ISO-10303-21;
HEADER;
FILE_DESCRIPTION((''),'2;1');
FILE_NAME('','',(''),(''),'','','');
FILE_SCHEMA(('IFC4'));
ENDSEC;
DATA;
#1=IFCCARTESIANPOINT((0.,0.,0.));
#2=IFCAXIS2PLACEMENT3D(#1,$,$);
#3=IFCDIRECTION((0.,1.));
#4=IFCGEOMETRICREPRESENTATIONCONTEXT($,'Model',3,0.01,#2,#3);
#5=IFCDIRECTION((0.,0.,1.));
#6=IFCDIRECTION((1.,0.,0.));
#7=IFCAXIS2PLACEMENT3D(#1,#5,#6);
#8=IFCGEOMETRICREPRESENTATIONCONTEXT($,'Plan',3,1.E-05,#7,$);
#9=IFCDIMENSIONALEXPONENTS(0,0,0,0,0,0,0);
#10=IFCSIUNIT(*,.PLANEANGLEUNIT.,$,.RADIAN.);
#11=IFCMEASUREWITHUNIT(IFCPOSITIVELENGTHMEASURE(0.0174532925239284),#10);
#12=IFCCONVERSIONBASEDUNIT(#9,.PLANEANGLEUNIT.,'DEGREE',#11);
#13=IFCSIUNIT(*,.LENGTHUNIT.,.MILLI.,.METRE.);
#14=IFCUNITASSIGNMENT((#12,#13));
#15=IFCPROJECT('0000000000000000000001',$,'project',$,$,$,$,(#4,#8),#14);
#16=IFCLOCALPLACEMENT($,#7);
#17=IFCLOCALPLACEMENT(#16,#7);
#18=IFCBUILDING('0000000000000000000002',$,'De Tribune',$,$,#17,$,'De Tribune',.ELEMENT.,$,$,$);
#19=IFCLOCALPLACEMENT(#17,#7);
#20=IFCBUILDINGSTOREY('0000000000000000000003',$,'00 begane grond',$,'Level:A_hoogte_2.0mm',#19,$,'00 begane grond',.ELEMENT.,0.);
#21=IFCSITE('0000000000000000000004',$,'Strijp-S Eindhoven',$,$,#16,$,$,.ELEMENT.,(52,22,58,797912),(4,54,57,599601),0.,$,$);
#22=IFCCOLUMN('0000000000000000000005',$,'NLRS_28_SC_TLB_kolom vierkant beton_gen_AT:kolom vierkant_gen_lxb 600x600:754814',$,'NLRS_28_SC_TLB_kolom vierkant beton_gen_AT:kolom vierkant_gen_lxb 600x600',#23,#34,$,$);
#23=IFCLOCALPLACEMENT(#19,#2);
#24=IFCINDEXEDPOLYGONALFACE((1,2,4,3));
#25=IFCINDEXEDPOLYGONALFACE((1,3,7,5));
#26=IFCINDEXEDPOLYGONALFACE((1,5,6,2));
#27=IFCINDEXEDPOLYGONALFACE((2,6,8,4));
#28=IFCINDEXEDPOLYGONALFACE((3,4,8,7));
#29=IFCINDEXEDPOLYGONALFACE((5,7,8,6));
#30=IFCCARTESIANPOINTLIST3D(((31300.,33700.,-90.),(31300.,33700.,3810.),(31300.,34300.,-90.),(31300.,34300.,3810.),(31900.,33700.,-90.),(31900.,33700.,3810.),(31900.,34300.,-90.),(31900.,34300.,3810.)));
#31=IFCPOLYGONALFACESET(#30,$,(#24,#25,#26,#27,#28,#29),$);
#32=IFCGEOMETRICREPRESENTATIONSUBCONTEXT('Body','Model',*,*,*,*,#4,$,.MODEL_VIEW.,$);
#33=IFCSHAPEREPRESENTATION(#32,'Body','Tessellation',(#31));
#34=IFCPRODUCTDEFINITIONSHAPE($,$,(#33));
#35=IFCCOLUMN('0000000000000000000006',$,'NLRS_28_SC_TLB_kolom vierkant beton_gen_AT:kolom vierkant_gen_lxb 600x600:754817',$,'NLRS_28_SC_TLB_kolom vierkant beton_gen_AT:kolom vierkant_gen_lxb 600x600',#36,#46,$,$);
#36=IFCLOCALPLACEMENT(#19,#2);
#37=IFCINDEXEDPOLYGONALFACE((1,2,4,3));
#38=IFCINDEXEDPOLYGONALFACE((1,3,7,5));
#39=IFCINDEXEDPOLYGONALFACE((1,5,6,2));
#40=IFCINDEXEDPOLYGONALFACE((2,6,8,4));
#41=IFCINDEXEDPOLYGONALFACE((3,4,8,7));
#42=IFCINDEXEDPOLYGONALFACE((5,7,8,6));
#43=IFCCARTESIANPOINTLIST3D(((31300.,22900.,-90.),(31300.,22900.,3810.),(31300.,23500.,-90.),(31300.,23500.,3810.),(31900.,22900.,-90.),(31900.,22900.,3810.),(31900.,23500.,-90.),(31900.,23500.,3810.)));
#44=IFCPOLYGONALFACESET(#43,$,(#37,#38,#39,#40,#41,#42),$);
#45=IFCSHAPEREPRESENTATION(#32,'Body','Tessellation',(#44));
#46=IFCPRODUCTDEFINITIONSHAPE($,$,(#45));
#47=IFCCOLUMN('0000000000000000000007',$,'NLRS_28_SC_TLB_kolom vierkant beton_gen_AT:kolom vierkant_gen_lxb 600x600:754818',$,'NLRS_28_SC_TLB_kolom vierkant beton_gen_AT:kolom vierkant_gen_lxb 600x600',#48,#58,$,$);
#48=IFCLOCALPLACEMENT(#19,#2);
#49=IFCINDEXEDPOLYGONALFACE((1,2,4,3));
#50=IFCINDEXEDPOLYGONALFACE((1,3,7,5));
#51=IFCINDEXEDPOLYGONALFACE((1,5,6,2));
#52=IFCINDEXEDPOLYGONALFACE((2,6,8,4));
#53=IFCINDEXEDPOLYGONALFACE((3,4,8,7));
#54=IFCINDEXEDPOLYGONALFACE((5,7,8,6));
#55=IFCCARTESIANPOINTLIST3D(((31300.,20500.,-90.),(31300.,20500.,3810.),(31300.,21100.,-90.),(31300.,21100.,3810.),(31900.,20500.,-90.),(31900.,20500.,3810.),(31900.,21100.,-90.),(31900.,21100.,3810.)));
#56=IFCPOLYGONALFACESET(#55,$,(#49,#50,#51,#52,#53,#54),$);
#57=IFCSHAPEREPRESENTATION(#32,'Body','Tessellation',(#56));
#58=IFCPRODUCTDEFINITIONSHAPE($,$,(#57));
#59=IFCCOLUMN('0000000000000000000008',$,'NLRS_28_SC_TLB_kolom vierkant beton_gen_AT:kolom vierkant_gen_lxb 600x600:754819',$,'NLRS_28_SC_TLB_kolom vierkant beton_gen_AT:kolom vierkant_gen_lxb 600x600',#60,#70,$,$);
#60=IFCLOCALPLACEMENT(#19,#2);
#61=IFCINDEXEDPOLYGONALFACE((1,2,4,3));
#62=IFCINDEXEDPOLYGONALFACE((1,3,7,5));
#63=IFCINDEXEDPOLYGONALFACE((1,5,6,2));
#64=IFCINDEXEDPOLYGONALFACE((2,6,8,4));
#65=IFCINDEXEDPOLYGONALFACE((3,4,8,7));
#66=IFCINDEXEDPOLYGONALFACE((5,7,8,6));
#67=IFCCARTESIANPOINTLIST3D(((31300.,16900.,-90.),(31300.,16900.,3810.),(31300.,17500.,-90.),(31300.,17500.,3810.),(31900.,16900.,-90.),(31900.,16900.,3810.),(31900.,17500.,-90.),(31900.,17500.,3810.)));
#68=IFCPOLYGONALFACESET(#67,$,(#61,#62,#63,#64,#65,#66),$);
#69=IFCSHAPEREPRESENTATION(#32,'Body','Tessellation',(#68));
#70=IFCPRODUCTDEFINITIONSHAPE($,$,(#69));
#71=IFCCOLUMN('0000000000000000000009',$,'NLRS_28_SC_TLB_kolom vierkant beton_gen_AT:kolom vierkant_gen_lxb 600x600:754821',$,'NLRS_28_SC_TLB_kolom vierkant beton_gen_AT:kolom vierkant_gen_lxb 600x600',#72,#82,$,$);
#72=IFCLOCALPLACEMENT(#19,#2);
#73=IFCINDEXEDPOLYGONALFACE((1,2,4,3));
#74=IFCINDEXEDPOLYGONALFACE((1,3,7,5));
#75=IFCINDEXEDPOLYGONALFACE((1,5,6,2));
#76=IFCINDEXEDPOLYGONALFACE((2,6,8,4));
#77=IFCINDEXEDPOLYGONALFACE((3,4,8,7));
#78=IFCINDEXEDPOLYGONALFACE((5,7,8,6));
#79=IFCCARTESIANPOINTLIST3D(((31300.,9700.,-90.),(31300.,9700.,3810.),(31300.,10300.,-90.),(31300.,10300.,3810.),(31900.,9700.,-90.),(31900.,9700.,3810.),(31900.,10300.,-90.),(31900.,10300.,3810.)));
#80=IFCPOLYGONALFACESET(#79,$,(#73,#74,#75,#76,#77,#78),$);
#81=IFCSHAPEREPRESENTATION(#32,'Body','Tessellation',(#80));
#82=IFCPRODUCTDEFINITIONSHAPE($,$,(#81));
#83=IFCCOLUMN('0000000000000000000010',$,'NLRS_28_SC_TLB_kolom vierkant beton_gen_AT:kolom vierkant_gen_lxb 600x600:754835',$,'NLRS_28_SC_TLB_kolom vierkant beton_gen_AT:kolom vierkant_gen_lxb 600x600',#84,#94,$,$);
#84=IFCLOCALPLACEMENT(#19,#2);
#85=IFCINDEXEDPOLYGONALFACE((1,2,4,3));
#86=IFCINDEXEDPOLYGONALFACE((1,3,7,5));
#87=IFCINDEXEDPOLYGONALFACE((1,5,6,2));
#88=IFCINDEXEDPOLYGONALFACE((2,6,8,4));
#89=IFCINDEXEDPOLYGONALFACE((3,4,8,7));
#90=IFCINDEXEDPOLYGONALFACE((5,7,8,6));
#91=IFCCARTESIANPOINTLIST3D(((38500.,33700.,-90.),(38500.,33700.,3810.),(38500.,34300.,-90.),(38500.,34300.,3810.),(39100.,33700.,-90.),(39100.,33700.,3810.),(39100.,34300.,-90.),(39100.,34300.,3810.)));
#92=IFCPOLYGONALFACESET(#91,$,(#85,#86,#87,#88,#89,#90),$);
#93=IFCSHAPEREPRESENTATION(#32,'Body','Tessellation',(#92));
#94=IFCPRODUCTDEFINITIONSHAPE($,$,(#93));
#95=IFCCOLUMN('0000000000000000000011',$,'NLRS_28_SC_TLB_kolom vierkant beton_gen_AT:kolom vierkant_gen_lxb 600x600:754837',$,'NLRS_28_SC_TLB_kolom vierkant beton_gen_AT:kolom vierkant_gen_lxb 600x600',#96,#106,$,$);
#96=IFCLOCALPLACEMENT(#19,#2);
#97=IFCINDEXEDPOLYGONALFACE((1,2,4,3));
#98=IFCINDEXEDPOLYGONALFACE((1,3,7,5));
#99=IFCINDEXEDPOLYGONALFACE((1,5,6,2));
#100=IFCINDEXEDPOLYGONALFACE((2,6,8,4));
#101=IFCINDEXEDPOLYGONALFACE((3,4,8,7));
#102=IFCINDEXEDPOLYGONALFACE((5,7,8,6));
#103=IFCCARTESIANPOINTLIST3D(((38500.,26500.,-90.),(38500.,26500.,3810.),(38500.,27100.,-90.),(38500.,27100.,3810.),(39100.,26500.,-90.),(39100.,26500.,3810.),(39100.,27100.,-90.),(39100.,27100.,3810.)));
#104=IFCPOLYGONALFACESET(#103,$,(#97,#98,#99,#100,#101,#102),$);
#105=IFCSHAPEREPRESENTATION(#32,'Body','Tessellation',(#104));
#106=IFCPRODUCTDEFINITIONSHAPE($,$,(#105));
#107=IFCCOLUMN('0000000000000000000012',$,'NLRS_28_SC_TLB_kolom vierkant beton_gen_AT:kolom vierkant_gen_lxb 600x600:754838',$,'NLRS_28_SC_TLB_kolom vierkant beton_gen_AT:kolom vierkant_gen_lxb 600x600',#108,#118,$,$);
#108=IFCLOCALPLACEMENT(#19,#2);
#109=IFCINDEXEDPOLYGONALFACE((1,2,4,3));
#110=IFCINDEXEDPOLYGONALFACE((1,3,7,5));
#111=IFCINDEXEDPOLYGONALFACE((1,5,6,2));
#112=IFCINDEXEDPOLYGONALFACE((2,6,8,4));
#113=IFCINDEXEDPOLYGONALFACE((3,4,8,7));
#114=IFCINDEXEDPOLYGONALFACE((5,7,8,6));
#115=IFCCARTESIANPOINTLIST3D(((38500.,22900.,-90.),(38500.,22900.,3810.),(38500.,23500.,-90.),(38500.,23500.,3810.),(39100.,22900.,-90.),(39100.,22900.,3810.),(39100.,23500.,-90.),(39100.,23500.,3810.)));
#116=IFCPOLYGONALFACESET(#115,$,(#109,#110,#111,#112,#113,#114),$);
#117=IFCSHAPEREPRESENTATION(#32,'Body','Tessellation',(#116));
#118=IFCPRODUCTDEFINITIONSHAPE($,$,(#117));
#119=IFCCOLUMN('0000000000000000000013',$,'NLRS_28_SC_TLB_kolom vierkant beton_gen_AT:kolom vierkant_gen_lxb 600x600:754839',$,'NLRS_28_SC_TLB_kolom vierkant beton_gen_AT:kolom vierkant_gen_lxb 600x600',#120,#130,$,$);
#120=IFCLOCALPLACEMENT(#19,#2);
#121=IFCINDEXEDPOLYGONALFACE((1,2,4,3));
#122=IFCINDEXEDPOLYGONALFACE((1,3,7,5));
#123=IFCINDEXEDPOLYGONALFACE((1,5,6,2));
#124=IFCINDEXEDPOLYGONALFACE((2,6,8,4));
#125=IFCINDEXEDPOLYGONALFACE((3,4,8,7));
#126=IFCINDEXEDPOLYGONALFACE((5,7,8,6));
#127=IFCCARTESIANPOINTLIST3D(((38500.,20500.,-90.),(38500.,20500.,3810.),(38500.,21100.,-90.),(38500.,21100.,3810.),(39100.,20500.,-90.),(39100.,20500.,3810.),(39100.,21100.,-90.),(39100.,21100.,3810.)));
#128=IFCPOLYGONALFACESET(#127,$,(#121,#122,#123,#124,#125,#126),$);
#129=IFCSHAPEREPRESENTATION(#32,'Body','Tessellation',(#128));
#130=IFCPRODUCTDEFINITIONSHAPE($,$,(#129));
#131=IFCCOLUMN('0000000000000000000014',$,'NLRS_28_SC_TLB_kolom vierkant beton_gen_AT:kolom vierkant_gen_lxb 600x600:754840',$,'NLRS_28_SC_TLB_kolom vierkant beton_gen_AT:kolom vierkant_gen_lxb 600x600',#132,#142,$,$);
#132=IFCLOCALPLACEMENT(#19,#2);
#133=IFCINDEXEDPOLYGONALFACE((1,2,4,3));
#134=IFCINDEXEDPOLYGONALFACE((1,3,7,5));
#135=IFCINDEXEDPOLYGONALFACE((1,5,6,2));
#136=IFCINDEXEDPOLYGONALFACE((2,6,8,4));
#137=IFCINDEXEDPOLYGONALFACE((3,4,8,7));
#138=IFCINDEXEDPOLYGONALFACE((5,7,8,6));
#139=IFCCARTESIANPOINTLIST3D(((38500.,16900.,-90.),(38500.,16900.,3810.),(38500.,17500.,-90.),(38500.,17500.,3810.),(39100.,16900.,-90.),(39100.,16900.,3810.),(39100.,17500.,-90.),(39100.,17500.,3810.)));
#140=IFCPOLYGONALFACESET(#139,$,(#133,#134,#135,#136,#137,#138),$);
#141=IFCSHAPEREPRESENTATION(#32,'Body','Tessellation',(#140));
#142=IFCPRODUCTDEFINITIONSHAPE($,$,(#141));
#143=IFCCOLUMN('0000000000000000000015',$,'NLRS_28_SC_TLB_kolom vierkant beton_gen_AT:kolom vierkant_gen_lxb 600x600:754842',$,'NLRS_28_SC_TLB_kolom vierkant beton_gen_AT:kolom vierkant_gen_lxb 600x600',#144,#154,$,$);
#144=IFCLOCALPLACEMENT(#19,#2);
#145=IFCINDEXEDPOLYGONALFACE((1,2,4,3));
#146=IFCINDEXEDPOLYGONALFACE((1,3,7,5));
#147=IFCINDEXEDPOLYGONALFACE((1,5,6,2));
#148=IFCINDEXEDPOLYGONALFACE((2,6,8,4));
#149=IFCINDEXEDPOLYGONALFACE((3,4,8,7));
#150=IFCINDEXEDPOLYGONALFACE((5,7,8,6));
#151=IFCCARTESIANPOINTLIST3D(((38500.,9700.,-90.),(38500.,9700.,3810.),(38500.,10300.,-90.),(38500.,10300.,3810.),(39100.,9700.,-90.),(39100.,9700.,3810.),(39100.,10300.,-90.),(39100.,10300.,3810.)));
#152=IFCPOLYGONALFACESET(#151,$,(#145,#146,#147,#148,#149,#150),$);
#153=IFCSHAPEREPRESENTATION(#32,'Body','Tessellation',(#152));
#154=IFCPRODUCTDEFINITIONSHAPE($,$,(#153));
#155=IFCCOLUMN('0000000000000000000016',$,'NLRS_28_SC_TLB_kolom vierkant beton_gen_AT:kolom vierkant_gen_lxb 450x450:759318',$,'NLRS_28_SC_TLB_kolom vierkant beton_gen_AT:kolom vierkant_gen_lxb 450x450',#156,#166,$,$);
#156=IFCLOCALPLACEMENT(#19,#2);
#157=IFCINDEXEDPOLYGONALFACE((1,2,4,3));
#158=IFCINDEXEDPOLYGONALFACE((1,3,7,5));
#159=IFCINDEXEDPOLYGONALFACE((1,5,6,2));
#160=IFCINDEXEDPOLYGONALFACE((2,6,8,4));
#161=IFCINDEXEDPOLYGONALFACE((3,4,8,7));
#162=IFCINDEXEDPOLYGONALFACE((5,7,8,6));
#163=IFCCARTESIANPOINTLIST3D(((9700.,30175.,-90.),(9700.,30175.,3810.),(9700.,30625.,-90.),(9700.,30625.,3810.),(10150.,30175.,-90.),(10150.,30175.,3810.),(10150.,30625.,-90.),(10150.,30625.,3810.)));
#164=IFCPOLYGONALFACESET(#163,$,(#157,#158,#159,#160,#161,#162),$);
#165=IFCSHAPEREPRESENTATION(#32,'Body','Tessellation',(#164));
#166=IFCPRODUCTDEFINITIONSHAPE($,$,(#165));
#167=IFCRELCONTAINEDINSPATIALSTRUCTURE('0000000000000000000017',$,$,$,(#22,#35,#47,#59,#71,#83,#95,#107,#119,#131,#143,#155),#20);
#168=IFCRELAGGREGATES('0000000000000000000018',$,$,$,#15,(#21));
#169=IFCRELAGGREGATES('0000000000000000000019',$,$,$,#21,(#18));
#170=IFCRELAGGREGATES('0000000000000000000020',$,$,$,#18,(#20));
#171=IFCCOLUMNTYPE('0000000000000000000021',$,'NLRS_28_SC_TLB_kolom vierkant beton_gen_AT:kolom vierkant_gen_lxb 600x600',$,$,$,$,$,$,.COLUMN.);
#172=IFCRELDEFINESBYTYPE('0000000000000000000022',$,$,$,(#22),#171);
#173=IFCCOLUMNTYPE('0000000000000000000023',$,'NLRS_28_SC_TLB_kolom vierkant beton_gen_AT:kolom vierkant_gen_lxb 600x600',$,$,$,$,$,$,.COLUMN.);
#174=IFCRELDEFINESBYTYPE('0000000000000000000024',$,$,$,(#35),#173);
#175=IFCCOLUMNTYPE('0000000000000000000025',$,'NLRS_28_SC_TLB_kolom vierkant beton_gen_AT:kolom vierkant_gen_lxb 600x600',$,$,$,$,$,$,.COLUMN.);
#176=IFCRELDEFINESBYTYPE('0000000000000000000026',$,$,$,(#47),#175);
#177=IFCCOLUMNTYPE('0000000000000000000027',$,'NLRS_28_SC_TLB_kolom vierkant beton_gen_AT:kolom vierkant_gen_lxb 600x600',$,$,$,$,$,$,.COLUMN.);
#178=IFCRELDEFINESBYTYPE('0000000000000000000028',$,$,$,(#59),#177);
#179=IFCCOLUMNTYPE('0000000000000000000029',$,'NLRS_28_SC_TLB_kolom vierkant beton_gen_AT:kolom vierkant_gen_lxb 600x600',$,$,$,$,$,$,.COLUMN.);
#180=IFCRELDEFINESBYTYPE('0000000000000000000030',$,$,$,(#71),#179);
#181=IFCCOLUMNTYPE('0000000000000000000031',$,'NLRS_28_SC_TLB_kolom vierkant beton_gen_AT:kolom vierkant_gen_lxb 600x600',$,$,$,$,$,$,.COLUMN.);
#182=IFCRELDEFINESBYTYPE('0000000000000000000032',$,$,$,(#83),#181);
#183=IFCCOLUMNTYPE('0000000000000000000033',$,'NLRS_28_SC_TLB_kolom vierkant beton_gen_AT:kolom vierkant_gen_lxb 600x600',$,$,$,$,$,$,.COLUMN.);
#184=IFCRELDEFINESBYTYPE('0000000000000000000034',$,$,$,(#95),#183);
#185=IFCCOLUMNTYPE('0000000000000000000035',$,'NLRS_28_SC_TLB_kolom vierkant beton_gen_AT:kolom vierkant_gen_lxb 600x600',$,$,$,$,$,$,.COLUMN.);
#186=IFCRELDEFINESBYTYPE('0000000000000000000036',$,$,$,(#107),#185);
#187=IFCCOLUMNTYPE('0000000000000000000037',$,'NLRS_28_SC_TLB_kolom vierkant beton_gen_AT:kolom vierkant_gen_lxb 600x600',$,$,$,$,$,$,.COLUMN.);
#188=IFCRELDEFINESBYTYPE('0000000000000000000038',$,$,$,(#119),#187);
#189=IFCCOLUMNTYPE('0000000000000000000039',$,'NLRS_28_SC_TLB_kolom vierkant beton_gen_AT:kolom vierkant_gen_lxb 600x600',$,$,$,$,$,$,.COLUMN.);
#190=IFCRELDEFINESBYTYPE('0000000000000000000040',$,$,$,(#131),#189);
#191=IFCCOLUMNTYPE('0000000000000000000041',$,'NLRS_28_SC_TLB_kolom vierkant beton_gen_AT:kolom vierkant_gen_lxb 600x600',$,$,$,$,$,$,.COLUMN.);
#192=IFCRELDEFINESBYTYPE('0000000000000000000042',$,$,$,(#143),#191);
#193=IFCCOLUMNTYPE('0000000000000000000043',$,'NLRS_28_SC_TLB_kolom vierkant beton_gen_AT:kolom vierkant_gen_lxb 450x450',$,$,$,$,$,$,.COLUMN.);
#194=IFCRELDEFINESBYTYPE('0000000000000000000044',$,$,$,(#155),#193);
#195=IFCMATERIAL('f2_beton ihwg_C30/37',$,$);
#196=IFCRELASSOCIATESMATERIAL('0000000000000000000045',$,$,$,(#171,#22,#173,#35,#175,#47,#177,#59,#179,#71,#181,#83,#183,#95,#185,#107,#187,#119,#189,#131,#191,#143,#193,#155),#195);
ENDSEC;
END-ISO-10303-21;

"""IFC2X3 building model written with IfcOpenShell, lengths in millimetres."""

from ifc_helpers import new_model, entity, si_unit, converted_unit, direction, frame, frame_2d, origin, origin_with_axes, place, context, subcontext, project, spatial, rectangle, extrude, source, transform, mapped, material, type_object, element, save


model = new_model("IFC2X3")

# Units and contexts
model_context = context("Model", 3, precision=0.01, world=origin(), true_north=direction((0.0, 1.0)))
plan_context = context("Plan", 3, precision=1e-05, world=origin_with_axes())
body_context = subcontext(model_context, "Body", "Model", "MODEL_VIEW")
ifc_project = project(units=[converted_unit("PLANEANGLEUNIT", "DEGREE", entity("IfcPositiveLengthMeasure", 0.0174532925239284), si_unit("PLANEANGLEUNIT", "RADIAN"), dimensions=[0, 0, 0, 0, 0, 0, 0]), si_unit("LENGTHUNIT", "METRE", prefix="MILLI")], contexts=[model_context, plan_context])

# Site, building, storey
site_placement = place(None, origin_with_axes())
site = spatial("IfcSite", under=ifc_project, at=site_placement, Name="Strijp-S Eindhoven", CompositionType="ELEMENT", RefLatitude=(52, 22, 58, 797912), RefLongitude=(4, 54, 57, 599601), RefElevation=0.0)
building_placement = place(site_placement, origin_with_axes())
building = spatial("IfcBuilding", under=site, at=building_placement, Name="De Tribune", LongName="De Tribune", CompositionType="ELEMENT")
storey_placement = place(building_placement, origin_with_axes())
storey = spatial("IfcBuildingStorey", under=building, at=storey_placement, Name="00 begane grond", ObjectType="Level:A_hoogte_2.0mm", LongName="00 begane grond", CompositionType="ELEMENT", Elevation=0.0)

# Columns
ifc_material_1 = material(Name="f2_beton ihwg_C30/37")
column_type_1 = type_object("IfcColumnType", Name="NLRS_28_SC_TLB_kolom vierkant beton_gen_AT:kolom vierkant_gen_lxb 600x600", PredefinedType="COLUMN", material=ifc_material_1)
shared_shape_1 = source(origin(), body_context, "Body", "SweptSolid", [
    extrude(rectangle(XDim=600.0, YDim=600.0, at=frame_2d((0.0, 0.0), x_axis=(1.0, 0.0))), frame((31600.0, 34000.0, -90.0), z_axis=(0.0, 0.0, 1.0), x_axis=(-1.0, 0.0, 0.0)), (0.0, 0.0, 1.0), 3900.0),
])
column_1_placement = place(storey_placement, origin_with_axes())
element("IfcColumn", 1, at=column_1_placement, inside=storey, type_object=column_type_1, material=ifc_material_1, Name="NLRS_28_SC_TLB_kolom vierkant beton_gen_AT:kolom vierkant_gen_lxb 600x600:754814", ObjectType="NLRS_28_SC_TLB_kolom vierkant beton_gen_AT:kolom vierkant_gen_lxb 600x600", context=body_context, shape_type="MappedRepresentation", body=[
    mapped(shared_shape_1, transform((0.0, 0.0, 0.0), scale=1.0)),
])
column_type_2 = type_object("IfcColumnType", Name="NLRS_28_SC_TLB_kolom vierkant beton_gen_AT:kolom vierkant_gen_lxb 600x600", PredefinedType="COLUMN", material=ifc_material_1)
shared_shape_2 = source(origin(), body_context, "Body", "SweptSolid", [
    extrude(rectangle(XDim=600.0, YDim=600.0, at=frame_2d((0.0, 0.0), x_axis=(1.0, 0.0))), frame((31600.0, 23200.0, -90.0), z_axis=(0.0, 0.0, 1.0), x_axis=(-1.0, 0.0, 0.0)), (0.0, 0.0, 1.0), 3900.0),
])
column_2_placement = place(storey_placement, origin_with_axes())
element("IfcColumn", 2, at=column_2_placement, inside=storey, type_object=column_type_2, material=ifc_material_1, Name="NLRS_28_SC_TLB_kolom vierkant beton_gen_AT:kolom vierkant_gen_lxb 600x600:754817", ObjectType="NLRS_28_SC_TLB_kolom vierkant beton_gen_AT:kolom vierkant_gen_lxb 600x600", context=body_context, shape_type="MappedRepresentation", body=[
    mapped(shared_shape_2, transform((0.0, 0.0, 0.0), scale=1.0)),
])
column_type_3 = type_object("IfcColumnType", Name="NLRS_28_SC_TLB_kolom vierkant beton_gen_AT:kolom vierkant_gen_lxb 600x600", PredefinedType="COLUMN", material=ifc_material_1)
shared_shape_3 = source(origin(), body_context, "Body", "SweptSolid", [
    extrude(rectangle(XDim=600.0, YDim=600.0, at=frame_2d((0.0, 0.0), x_axis=(1.0, 0.0))), frame((31600.0, 20800.0, -90.0), z_axis=(0.0, 0.0, 1.0), x_axis=(-1.0, 0.0, 0.0)), (0.0, 0.0, 1.0), 3900.0),
])
column_3_placement = place(storey_placement, origin_with_axes())
element("IfcColumn", 3, at=column_3_placement, inside=storey, type_object=column_type_3, material=ifc_material_1, Name="NLRS_28_SC_TLB_kolom vierkant beton_gen_AT:kolom vierkant_gen_lxb 600x600:754818", ObjectType="NLRS_28_SC_TLB_kolom vierkant beton_gen_AT:kolom vierkant_gen_lxb 600x600", context=body_context, shape_type="MappedRepresentation", body=[
    mapped(shared_shape_3, transform((0.0, 0.0, 0.0), scale=1.0)),
])
column_type_4 = type_object("IfcColumnType", Name="NLRS_28_SC_TLB_kolom vierkant beton_gen_AT:kolom vierkant_gen_lxb 600x600", PredefinedType="COLUMN", material=ifc_material_1)
shared_shape_4 = source(origin(), body_context, "Body", "SweptSolid", [
    extrude(rectangle(XDim=600.0, YDim=600.0, at=frame_2d((0.0, 0.0), x_axis=(1.0, 0.0))), frame((31600.0, 17200.0, -90.0), z_axis=(0.0, 0.0, 1.0), x_axis=(-1.0, 0.0, 0.0)), (0.0, 0.0, 1.0), 3900.0),
])
column_4_placement = place(storey_placement, origin_with_axes())
element("IfcColumn", 4, at=column_4_placement, inside=storey, type_object=column_type_4, material=ifc_material_1, Name="NLRS_28_SC_TLB_kolom vierkant beton_gen_AT:kolom vierkant_gen_lxb 600x600:754819", ObjectType="NLRS_28_SC_TLB_kolom vierkant beton_gen_AT:kolom vierkant_gen_lxb 600x600", context=body_context, shape_type="MappedRepresentation", body=[
    mapped(shared_shape_4, transform((0.0, 0.0, 0.0), scale=1.0)),
])
column_type_5 = type_object("IfcColumnType", Name="NLRS_28_SC_TLB_kolom vierkant beton_gen_AT:kolom vierkant_gen_lxb 600x600", PredefinedType="COLUMN", material=ifc_material_1)
shared_shape_5 = source(origin(), body_context, "Body", "SweptSolid", [
    extrude(rectangle(XDim=600.0, YDim=600.0, at=frame_2d((0.0, 0.0), x_axis=(1.0, 0.0))), frame((31600.0, 10000.0, -90.0), z_axis=(0.0, 0.0, 1.0), x_axis=(-1.0, 0.0, 0.0)), (0.0, 0.0, 1.0), 3900.0),
])
column_5_placement = place(storey_placement, origin_with_axes())
element("IfcColumn", 5, at=column_5_placement, inside=storey, type_object=column_type_5, material=ifc_material_1, Name="NLRS_28_SC_TLB_kolom vierkant beton_gen_AT:kolom vierkant_gen_lxb 600x600:754821", ObjectType="NLRS_28_SC_TLB_kolom vierkant beton_gen_AT:kolom vierkant_gen_lxb 600x600", context=body_context, shape_type="MappedRepresentation", body=[
    mapped(shared_shape_5, transform((0.0, 0.0, 0.0), scale=1.0)),
])
column_type_6 = type_object("IfcColumnType", Name="NLRS_28_SC_TLB_kolom vierkant beton_gen_AT:kolom vierkant_gen_lxb 600x600", PredefinedType="COLUMN", material=ifc_material_1)
shared_shape_6 = source(origin(), body_context, "Body", "SweptSolid", [
    extrude(rectangle(XDim=600.0, YDim=600.0, at=frame_2d((0.0, 0.0), x_axis=(1.0, 0.0))), frame((38800.0, 34000.0, -90.0), z_axis=(0.0, 0.0, 1.0), x_axis=(-1.0, 0.0, 0.0)), (0.0, 0.0, 1.0), 3900.0),
])
column_6_placement = place(storey_placement, origin_with_axes())
element("IfcColumn", 6, at=column_6_placement, inside=storey, type_object=column_type_6, material=ifc_material_1, Name="NLRS_28_SC_TLB_kolom vierkant beton_gen_AT:kolom vierkant_gen_lxb 600x600:754835", ObjectType="NLRS_28_SC_TLB_kolom vierkant beton_gen_AT:kolom vierkant_gen_lxb 600x600", context=body_context, shape_type="MappedRepresentation", body=[
    mapped(shared_shape_6, transform((0.0, 0.0, 0.0), scale=1.0)),
])
column_type_7 = type_object("IfcColumnType", Name="NLRS_28_SC_TLB_kolom vierkant beton_gen_AT:kolom vierkant_gen_lxb 600x600", PredefinedType="COLUMN", material=ifc_material_1)
shared_shape_7 = source(origin(), body_context, "Body", "SweptSolid", [
    extrude(rectangle(XDim=600.0, YDim=600.0, at=frame_2d((0.0, 0.0), x_axis=(1.0, 0.0))), frame((38800.0, 26800.0, -90.0), z_axis=(0.0, 0.0, 1.0), x_axis=(-1.0, 0.0, 0.0)), (0.0, 0.0, 1.0), 3900.0),
])
column_7_placement = place(storey_placement, origin_with_axes())
element("IfcColumn", 7, at=column_7_placement, inside=storey, type_object=column_type_7, material=ifc_material_1, Name="NLRS_28_SC_TLB_kolom vierkant beton_gen_AT:kolom vierkant_gen_lxb 600x600:754837", ObjectType="NLRS_28_SC_TLB_kolom vierkant beton_gen_AT:kolom vierkant_gen_lxb 600x600", context=body_context, shape_type="MappedRepresentation", body=[
    mapped(shared_shape_7, transform((0.0, 0.0, 0.0), scale=1.0)),
])
column_type_8 = type_object("IfcColumnType", Name="NLRS_28_SC_TLB_kolom vierkant beton_gen_AT:kolom vierkant_gen_lxb 600x600", PredefinedType="COLUMN", material=ifc_material_1)
shared_shape_8 = source(origin(), body_context, "Body", "SweptSolid", [
    extrude(rectangle(XDim=600.0, YDim=600.0, at=frame_2d((0.0, 0.0), x_axis=(1.0, 0.0))), frame((38800.0, 23200.0, -90.0), z_axis=(0.0, 0.0, 1.0), x_axis=(-1.0, 0.0, 0.0)), (0.0, 0.0, 1.0), 3900.0),
])
column_8_placement = place(storey_placement, origin_with_axes())
element("IfcColumn", 8, at=column_8_placement, inside=storey, type_object=column_type_8, material=ifc_material_1, Name="NLRS_28_SC_TLB_kolom vierkant beton_gen_AT:kolom vierkant_gen_lxb 600x600:754838", ObjectType="NLRS_28_SC_TLB_kolom vierkant beton_gen_AT:kolom vierkant_gen_lxb 600x600", context=body_context, shape_type="MappedRepresentation", body=[
    mapped(shared_shape_8, transform((0.0, 0.0, 0.0), scale=1.0)),
])
column_type_9 = type_object("IfcColumnType", Name="NLRS_28_SC_TLB_kolom vierkant beton_gen_AT:kolom vierkant_gen_lxb 600x600", PredefinedType="COLUMN", material=ifc_material_1)
shared_shape_9 = source(origin(), body_context, "Body", "SweptSolid", [
    extrude(rectangle(XDim=600.0, YDim=600.0, at=frame_2d((0.0, 0.0), x_axis=(1.0, 0.0))), frame((38800.0, 20800.0, -90.0), z_axis=(0.0, 0.0, 1.0), x_axis=(-1.0, 0.0, 0.0)), (0.0, 0.0, 1.0), 3900.0),
])
column_9_placement = place(storey_placement, origin_with_axes())
element("IfcColumn", 9, at=column_9_placement, inside=storey, type_object=column_type_9, material=ifc_material_1, Name="NLRS_28_SC_TLB_kolom vierkant beton_gen_AT:kolom vierkant_gen_lxb 600x600:754839", ObjectType="NLRS_28_SC_TLB_kolom vierkant beton_gen_AT:kolom vierkant_gen_lxb 600x600", context=body_context, shape_type="MappedRepresentation", body=[
    mapped(shared_shape_9, transform((0.0, 0.0, 0.0), scale=1.0)),
])
column_type_10 = type_object("IfcColumnType", Name="NLRS_28_SC_TLB_kolom vierkant beton_gen_AT:kolom vierkant_gen_lxb 600x600", PredefinedType="COLUMN", material=ifc_material_1)
shared_shape_10 = source(origin(), body_context, "Body", "SweptSolid", [
    extrude(rectangle(XDim=600.0, YDim=600.0, at=frame_2d((0.0, 0.0), x_axis=(1.0, 0.0))), frame((38800.0, 17200.0, -90.0), z_axis=(0.0, 0.0, 1.0), x_axis=(-1.0, 0.0, 0.0)), (0.0, 0.0, 1.0), 3900.0),
])
column_10_placement = place(storey_placement, origin_with_axes())
element("IfcColumn", 10, at=column_10_placement, inside=storey, type_object=column_type_10, material=ifc_material_1, Name="NLRS_28_SC_TLB_kolom vierkant beton_gen_AT:kolom vierkant_gen_lxb 600x600:754840", ObjectType="NLRS_28_SC_TLB_kolom vierkant beton_gen_AT:kolom vierkant_gen_lxb 600x600", context=body_context, shape_type="MappedRepresentation", body=[
    mapped(shared_shape_10, transform((0.0, 0.0, 0.0), scale=1.0)),
])
column_type_11 = type_object("IfcColumnType", Name="NLRS_28_SC_TLB_kolom vierkant beton_gen_AT:kolom vierkant_gen_lxb 600x600", PredefinedType="COLUMN", material=ifc_material_1)
shared_shape_11 = source(origin(), body_context, "Body", "SweptSolid", [
    extrude(rectangle(XDim=600.0, YDim=600.0, at=frame_2d((0.0, 0.0), x_axis=(1.0, 0.0))), frame((38800.0, 10000.0, -90.0), z_axis=(0.0, 0.0, 1.0), x_axis=(-1.0, 0.0, 0.0)), (0.0, 0.0, 1.0), 3900.0),
])
column_11_placement = place(storey_placement, origin_with_axes())
element("IfcColumn", 11, at=column_11_placement, inside=storey, type_object=column_type_11, material=ifc_material_1, Name="NLRS_28_SC_TLB_kolom vierkant beton_gen_AT:kolom vierkant_gen_lxb 600x600:754842", ObjectType="NLRS_28_SC_TLB_kolom vierkant beton_gen_AT:kolom vierkant_gen_lxb 600x600", context=body_context, shape_type="MappedRepresentation", body=[
    mapped(shared_shape_11, transform((0.0, 0.0, 0.0), scale=1.0)),
])
column_type_12 = type_object("IfcColumnType", Name="NLRS_28_SC_TLB_kolom vierkant beton_gen_AT:kolom vierkant_gen_lxb 450x450", PredefinedType="COLUMN", material=ifc_material_1)
shared_shape_12 = source(origin(), body_context, "Body", "SweptSolid", [
    extrude(rectangle(XDim=450.0, YDim=450.0, at=frame_2d((0.0, 0.0), x_axis=(1.0, 0.0))), frame((9925.0, 30400.0, -90.0), z_axis=(0.0, 0.0, 1.0), x_axis=(-1.0, 0.0, 0.0)), (0.0, 0.0, 1.0), 3900.0),
])
column_12_placement = place(storey_placement, origin_with_axes())
element("IfcColumn", 12, at=column_12_placement, inside=storey, type_object=column_type_12, material=ifc_material_1, Name="NLRS_28_SC_TLB_kolom vierkant beton_gen_AT:kolom vierkant_gen_lxb 450x450:759318", ObjectType="NLRS_28_SC_TLB_kolom vierkant beton_gen_AT:kolom vierkant_gen_lxb 450x450", context=body_context, shape_type="MappedRepresentation", body=[
    mapped(shared_shape_12, transform((0.0, 0.0, 0.0), scale=1.0)),
])

save(model, "model.ifc")
